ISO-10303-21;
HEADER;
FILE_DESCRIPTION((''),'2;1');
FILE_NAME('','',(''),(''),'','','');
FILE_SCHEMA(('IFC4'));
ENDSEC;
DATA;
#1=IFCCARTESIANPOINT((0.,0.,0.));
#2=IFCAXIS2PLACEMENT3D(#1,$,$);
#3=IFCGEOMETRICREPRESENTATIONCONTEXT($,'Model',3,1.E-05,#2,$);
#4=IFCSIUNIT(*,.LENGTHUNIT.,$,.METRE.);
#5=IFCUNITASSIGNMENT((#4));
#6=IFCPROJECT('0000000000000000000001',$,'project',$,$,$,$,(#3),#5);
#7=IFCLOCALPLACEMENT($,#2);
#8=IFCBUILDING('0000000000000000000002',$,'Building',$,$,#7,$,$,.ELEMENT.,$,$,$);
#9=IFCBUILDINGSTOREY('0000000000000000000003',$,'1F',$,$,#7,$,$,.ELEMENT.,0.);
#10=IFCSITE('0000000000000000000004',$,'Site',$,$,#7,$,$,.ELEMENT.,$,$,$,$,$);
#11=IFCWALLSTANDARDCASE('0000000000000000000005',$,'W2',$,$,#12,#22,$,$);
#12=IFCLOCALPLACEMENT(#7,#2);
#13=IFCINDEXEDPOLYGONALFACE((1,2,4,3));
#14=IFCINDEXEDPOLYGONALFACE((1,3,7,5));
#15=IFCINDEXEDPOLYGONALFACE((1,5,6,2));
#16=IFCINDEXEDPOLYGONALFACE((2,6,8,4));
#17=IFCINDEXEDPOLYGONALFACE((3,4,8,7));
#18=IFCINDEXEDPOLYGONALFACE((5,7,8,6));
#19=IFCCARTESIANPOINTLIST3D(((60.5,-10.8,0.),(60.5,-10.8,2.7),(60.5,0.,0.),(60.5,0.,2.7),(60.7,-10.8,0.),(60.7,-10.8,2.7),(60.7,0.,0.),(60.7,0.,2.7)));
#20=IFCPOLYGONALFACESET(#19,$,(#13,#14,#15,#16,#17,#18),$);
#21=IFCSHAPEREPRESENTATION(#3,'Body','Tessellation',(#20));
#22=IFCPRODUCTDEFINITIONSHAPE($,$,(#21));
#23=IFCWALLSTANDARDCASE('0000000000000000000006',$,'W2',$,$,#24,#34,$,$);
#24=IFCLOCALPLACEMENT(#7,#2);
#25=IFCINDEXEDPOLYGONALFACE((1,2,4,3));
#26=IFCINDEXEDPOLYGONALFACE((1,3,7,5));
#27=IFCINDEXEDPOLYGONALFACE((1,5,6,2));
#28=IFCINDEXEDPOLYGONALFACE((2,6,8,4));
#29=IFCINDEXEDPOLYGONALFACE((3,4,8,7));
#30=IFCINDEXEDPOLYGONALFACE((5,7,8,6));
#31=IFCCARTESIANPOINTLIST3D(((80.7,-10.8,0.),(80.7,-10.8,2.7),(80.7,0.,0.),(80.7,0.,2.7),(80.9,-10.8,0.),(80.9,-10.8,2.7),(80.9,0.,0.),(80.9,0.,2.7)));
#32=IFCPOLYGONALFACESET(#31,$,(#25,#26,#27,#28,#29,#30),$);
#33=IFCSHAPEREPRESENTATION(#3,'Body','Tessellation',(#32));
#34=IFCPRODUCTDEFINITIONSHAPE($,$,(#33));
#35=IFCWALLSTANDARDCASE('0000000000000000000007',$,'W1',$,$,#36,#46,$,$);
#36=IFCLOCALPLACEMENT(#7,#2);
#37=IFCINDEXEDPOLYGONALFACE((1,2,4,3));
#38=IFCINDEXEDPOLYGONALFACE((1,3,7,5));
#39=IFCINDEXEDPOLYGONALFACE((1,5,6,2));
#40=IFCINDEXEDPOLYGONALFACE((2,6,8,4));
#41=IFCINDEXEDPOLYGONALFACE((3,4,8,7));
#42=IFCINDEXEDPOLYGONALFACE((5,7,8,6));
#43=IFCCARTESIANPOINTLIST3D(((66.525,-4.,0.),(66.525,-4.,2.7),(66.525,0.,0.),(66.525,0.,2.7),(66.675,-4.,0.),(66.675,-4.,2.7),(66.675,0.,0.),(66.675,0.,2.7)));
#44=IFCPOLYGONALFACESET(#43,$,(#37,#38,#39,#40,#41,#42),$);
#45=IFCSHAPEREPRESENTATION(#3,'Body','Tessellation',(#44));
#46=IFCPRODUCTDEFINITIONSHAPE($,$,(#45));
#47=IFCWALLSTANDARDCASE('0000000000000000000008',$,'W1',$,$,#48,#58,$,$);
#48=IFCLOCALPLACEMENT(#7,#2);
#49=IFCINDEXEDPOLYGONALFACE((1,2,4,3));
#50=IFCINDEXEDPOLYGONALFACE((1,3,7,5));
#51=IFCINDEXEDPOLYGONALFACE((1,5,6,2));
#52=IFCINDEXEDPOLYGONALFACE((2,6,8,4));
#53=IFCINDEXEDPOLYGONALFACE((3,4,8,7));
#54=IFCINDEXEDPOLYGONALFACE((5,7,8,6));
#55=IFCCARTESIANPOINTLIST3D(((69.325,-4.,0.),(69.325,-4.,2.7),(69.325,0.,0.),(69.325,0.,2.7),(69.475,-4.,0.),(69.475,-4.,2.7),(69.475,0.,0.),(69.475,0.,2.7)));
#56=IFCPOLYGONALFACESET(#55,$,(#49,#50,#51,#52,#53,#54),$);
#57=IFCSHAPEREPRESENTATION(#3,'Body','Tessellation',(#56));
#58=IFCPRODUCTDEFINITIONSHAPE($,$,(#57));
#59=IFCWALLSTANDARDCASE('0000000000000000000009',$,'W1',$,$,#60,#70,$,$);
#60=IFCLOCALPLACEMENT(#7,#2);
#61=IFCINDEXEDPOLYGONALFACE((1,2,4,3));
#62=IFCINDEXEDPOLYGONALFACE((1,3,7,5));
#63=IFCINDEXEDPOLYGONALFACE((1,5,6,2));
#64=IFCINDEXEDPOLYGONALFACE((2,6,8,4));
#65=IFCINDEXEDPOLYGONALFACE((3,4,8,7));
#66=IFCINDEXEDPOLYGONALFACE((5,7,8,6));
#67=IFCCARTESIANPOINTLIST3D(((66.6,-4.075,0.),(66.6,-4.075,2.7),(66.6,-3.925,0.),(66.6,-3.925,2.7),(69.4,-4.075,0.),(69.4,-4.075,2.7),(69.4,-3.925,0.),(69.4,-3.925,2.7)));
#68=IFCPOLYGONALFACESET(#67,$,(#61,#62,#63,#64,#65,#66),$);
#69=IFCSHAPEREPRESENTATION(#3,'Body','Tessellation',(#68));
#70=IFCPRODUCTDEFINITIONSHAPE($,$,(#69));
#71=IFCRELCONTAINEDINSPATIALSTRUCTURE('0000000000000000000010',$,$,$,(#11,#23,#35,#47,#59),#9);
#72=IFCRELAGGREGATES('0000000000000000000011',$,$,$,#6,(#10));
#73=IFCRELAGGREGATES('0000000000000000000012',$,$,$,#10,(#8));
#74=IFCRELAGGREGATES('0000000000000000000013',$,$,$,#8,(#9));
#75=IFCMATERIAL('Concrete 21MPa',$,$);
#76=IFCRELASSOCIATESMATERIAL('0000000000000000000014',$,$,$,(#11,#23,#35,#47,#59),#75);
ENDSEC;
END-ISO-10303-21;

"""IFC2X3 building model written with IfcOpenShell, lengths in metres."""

from ifc_helpers import new_model, si_unit, frame, origin, origin_2d, place, context, project, spatial, rectangle, extrude, material, element, save


model = new_model("IFC2X3")

# Units and contexts
model_context = context("Model", 3, precision=1e-05, world=origin())
ifc_project = project(units=[si_unit("LENGTHUNIT", "METRE")], contexts=[model_context])

# Site, building, storey
placement = place(None, origin())
site = spatial("IfcSite", under=ifc_project, at=placement, Name="Site", CompositionType="ELEMENT")
building = spatial("IfcBuilding", under=site, at=placement, Name="Building", CompositionType="ELEMENT")
storey = spatial("IfcBuildingStorey", under=building, at=placement, Name="1F", CompositionType="ELEMENT", Elevation=0.0)

# Shared definitions
ifc_material = material(Name="Concrete 21MPa")

# Walls
for number, where, name in (
    (1, (60.6, -5.4, 0.0), "W2"),
    (2, (80.8, -5.4, 0.0), "W2"),
):
    element("IfcWallStandardCase", number, at=place(None, frame(where)), inside=storey, material=ifc_material, Name=name, context=model_context, shape_type="SweptSolid", body=[
        extrude(rectangle(XDim=0.2, YDim=10.8, at=origin_2d()), origin(), (0.0, 0.0, 1.0), 2.7),
    ])
for number, where, name in (
    (3, (66.6, -2.0, 0.0), "W1"),
    (4, (69.4, -2.0, 0.0), "W1"),
):
    element("IfcWallStandardCase", number, at=place(None, frame(where)), inside=storey, material=ifc_material, Name=name, context=model_context, shape_type="SweptSolid", body=[
        extrude(rectangle(XDim=0.15, YDim=4.0, at=origin_2d()), origin(), (0.0, 0.0, 1.0), 2.7),
    ])
wall_placement = place(None, frame((68.0, -4.0, 0.0)))
element("IfcWallStandardCase", 5, at=wall_placement, inside=storey, material=ifc_material, Name="W1", context=model_context, shape_type="SweptSolid", body=[
    extrude(rectangle(XDim=2.8, YDim=0.15, at=origin_2d()), origin(), (0.0, 0.0, 1.0), 2.7),
])

save(model, "model.ifc")
